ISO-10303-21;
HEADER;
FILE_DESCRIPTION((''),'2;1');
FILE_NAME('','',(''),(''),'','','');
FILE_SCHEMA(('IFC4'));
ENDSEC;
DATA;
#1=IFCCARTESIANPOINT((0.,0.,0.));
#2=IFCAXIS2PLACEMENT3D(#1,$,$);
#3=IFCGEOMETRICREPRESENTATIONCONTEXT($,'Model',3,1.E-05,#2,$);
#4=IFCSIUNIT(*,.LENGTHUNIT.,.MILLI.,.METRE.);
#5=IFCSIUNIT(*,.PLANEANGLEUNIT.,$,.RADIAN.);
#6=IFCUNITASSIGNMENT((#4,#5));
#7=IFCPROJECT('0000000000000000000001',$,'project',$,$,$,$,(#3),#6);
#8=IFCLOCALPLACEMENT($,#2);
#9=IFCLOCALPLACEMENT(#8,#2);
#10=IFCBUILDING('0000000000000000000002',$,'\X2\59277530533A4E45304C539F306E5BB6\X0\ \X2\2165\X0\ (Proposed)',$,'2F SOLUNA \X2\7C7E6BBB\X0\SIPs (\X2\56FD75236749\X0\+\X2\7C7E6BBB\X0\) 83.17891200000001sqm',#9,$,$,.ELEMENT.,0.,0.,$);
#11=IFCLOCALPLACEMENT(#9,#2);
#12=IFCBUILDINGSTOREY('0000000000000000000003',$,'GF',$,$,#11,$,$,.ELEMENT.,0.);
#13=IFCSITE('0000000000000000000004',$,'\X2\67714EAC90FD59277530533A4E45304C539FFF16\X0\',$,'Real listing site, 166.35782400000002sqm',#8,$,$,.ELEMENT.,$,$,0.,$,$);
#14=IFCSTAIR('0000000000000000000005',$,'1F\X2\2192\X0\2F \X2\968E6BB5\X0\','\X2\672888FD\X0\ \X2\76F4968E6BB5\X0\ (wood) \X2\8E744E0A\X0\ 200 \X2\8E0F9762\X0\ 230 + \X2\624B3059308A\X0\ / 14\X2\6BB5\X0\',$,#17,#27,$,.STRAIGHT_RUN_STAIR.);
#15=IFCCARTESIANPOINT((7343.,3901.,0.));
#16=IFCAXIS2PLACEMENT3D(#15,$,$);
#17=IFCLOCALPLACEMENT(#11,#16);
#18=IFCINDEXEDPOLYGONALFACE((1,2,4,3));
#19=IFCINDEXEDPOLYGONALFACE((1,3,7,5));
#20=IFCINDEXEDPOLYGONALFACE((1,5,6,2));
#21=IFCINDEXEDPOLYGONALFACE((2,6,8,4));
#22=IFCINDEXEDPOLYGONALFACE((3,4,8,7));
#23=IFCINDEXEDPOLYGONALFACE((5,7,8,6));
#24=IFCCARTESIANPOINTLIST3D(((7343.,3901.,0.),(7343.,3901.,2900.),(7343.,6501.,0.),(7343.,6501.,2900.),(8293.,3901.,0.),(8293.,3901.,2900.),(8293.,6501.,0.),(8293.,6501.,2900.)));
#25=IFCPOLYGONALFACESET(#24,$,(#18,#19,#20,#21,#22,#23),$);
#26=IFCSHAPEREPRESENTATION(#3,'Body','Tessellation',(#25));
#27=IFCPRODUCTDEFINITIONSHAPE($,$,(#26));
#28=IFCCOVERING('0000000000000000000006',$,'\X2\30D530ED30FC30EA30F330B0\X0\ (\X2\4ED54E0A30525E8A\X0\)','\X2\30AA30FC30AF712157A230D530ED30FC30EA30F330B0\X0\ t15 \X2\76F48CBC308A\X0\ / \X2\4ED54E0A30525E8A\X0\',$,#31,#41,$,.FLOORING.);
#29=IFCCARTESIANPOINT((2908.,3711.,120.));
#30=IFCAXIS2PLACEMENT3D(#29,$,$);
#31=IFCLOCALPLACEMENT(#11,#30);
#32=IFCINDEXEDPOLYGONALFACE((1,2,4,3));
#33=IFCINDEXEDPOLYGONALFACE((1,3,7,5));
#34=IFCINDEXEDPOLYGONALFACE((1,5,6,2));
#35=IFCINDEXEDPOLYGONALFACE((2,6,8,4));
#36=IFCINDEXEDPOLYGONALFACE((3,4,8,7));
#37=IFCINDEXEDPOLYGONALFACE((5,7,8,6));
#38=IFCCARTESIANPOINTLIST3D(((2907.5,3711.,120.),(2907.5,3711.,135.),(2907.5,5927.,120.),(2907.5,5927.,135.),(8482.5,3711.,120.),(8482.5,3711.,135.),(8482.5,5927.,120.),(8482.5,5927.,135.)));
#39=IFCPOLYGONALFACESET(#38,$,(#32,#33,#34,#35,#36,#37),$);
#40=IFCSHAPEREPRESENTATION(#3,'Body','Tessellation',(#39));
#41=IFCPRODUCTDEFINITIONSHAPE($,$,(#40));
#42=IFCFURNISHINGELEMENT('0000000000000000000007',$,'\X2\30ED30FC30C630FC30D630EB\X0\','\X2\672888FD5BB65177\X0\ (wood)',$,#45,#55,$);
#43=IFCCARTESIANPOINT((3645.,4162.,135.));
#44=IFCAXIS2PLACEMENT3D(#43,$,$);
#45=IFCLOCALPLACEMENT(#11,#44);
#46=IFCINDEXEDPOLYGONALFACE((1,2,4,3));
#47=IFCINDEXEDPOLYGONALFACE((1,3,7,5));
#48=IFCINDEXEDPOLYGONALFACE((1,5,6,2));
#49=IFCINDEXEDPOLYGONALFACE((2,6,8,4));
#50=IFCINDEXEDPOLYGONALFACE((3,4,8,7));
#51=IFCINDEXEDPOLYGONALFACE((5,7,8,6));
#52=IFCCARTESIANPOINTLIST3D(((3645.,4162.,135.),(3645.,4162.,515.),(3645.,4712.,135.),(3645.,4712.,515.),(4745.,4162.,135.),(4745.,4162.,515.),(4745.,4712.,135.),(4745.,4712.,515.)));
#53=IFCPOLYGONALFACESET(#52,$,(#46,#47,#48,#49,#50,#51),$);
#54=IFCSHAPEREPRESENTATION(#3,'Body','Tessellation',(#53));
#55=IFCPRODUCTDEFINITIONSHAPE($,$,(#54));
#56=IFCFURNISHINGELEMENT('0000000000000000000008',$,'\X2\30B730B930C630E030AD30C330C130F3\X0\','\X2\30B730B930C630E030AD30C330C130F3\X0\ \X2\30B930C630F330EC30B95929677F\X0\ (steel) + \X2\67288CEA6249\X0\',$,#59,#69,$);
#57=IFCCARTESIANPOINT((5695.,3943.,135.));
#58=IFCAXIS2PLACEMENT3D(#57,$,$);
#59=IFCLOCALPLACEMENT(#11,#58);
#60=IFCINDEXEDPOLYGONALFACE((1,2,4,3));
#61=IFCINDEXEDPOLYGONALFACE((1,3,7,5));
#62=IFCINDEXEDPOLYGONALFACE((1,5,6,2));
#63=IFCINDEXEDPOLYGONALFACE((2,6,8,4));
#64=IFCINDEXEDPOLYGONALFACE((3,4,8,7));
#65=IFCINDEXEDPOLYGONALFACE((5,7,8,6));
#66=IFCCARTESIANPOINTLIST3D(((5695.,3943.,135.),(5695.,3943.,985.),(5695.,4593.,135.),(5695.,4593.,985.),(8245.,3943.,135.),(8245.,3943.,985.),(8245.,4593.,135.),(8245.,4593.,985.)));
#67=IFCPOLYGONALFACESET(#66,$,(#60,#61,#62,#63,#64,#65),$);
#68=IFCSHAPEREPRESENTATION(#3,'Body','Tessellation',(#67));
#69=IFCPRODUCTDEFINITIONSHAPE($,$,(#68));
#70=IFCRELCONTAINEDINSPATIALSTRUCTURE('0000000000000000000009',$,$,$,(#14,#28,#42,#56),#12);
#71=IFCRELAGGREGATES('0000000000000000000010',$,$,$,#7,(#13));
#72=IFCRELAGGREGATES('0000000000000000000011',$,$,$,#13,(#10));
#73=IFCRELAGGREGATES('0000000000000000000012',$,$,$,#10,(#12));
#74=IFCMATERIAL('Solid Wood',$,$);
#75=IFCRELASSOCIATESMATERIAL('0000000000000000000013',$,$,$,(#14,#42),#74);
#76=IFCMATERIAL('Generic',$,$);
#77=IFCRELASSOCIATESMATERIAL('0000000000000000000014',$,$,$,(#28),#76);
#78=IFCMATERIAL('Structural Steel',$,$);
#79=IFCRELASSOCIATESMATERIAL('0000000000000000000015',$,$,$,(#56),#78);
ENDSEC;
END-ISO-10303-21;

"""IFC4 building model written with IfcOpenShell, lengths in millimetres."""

from ifc_helpers import new_model, si_unit, frame, frame_2d, origin, place, context, project, spatial, rectangle, extrude, material, element, save


model = new_model("IFC4")

# Units and contexts
model_context = context("Model", 3, precision=1e-05, world=origin())
ifc_project = project(units=[si_unit("LENGTHUNIT", "METRE", prefix="MILLI"), si_unit("PLANEANGLEUNIT", "RADIAN")], contexts=[model_context])

# Site, building, storey
site_placement = place(None, origin())
site = spatial("IfcSite", under=ifc_project, at=site_placement, Name="東京都大田区久が原６", ObjectType="Real listing site, 166.35782400000002sqm", CompositionType="ELEMENT", RefElevation=0.0)
building_placement = place(site_placement, origin())
building = spatial("IfcBuilding", under=site, at=building_placement, Name="大田区久が原の家 Ⅵ (Proposed)", ObjectType="2F SOLUNA 籾殻SIPs (国産杉+籾殻) 83.17891200000001sqm", CompositionType="ELEMENT", ElevationOfRefHeight=0.0, ElevationOfTerrain=0.0)
storey_placement = place(building_placement, origin())
storey = spatial("IfcBuildingStorey", under=building, at=storey_placement, Name="GF", CompositionType="ELEMENT", Elevation=0.0)

# Shared definitions
ifc_material_1 = material(Name="Solid Wood")

# Stair
stair_placement = place(storey_placement, frame((7343.0, 3901.0, 0.0)))
element("IfcStair", 1, at=stair_placement, inside=storey, material=ifc_material_1, Name="1F→2F 階段", Description="木製 直階段 (wood) 蹴上 200 踏面 230 + 手すり / 14段", PredefinedType="STRAIGHT_RUN_STAIR", context=model_context, shape_type="SweptSolid", body=[
    extrude(rectangle(XDim=950.0, YDim=2600.0, at=frame_2d((475.0, 1300.0))), frame((7343.0, 3901.0, 0.0)), (0.0, 0.0, 1.0), 2900.0),
])

# Covering
ifc_material_2 = material(Name="Generic")
covering_placement = place(storey_placement, frame((2908.0, 3711.0, 120.0)))
element("IfcCovering", 2, at=covering_placement, inside=storey, material=ifc_material_2, Name="フローリング (仕上げ床)", Description="オーク無垢フローリング t15 直貼り / 仕上げ床", PredefinedType="FLOORING", context=model_context, shape_type="SweptSolid", body=[
    extrude(rectangle(XDim=5575.0, YDim=2216.0, at=frame_2d((2787.0, 1108.0))), frame((2908.0, 3711.0, 120.0)), (0.0, 0.0, 1.0), 15.0),
])

# Furnishing elements
furnishing_1_placement = place(storey_placement, frame((3645.0, 4162.0, 135.0)))
element("IfcFurnishingElement", 3, at=furnishing_1_placement, inside=storey, material=ifc_material_1, Name="ローテーブル", Description="木製家具 (wood)", context=model_context, shape_type="SweptSolid", body=[
    extrude(rectangle(XDim=1100.0, YDim=550.0, at=frame_2d((550.0, 275.0))), frame((3645.0, 4162.0, 135.0)), (0.0, 0.0, 1.0), 380.0),
])
ifc_material_3 = material(Name="Structural Steel")
furnishing_2_placement = place(storey_placement, frame((5695.0, 3943.0, 135.0)))
element("IfcFurnishingElement", 4, at=furnishing_2_placement, inside=storey, material=ifc_material_3, Name="システムキッチン", Description="システムキッチン ステンレス天板 (steel) + 木質扉", context=model_context, shape_type="SweptSolid", body=[
    extrude(rectangle(XDim=2550.0, YDim=650.0, at=frame_2d((1275.0, 325.0))), frame((5695.0, 3943.0, 135.0)), (0.0, 0.0, 1.0), 850.0),
])

save(model, "model.ifc")
